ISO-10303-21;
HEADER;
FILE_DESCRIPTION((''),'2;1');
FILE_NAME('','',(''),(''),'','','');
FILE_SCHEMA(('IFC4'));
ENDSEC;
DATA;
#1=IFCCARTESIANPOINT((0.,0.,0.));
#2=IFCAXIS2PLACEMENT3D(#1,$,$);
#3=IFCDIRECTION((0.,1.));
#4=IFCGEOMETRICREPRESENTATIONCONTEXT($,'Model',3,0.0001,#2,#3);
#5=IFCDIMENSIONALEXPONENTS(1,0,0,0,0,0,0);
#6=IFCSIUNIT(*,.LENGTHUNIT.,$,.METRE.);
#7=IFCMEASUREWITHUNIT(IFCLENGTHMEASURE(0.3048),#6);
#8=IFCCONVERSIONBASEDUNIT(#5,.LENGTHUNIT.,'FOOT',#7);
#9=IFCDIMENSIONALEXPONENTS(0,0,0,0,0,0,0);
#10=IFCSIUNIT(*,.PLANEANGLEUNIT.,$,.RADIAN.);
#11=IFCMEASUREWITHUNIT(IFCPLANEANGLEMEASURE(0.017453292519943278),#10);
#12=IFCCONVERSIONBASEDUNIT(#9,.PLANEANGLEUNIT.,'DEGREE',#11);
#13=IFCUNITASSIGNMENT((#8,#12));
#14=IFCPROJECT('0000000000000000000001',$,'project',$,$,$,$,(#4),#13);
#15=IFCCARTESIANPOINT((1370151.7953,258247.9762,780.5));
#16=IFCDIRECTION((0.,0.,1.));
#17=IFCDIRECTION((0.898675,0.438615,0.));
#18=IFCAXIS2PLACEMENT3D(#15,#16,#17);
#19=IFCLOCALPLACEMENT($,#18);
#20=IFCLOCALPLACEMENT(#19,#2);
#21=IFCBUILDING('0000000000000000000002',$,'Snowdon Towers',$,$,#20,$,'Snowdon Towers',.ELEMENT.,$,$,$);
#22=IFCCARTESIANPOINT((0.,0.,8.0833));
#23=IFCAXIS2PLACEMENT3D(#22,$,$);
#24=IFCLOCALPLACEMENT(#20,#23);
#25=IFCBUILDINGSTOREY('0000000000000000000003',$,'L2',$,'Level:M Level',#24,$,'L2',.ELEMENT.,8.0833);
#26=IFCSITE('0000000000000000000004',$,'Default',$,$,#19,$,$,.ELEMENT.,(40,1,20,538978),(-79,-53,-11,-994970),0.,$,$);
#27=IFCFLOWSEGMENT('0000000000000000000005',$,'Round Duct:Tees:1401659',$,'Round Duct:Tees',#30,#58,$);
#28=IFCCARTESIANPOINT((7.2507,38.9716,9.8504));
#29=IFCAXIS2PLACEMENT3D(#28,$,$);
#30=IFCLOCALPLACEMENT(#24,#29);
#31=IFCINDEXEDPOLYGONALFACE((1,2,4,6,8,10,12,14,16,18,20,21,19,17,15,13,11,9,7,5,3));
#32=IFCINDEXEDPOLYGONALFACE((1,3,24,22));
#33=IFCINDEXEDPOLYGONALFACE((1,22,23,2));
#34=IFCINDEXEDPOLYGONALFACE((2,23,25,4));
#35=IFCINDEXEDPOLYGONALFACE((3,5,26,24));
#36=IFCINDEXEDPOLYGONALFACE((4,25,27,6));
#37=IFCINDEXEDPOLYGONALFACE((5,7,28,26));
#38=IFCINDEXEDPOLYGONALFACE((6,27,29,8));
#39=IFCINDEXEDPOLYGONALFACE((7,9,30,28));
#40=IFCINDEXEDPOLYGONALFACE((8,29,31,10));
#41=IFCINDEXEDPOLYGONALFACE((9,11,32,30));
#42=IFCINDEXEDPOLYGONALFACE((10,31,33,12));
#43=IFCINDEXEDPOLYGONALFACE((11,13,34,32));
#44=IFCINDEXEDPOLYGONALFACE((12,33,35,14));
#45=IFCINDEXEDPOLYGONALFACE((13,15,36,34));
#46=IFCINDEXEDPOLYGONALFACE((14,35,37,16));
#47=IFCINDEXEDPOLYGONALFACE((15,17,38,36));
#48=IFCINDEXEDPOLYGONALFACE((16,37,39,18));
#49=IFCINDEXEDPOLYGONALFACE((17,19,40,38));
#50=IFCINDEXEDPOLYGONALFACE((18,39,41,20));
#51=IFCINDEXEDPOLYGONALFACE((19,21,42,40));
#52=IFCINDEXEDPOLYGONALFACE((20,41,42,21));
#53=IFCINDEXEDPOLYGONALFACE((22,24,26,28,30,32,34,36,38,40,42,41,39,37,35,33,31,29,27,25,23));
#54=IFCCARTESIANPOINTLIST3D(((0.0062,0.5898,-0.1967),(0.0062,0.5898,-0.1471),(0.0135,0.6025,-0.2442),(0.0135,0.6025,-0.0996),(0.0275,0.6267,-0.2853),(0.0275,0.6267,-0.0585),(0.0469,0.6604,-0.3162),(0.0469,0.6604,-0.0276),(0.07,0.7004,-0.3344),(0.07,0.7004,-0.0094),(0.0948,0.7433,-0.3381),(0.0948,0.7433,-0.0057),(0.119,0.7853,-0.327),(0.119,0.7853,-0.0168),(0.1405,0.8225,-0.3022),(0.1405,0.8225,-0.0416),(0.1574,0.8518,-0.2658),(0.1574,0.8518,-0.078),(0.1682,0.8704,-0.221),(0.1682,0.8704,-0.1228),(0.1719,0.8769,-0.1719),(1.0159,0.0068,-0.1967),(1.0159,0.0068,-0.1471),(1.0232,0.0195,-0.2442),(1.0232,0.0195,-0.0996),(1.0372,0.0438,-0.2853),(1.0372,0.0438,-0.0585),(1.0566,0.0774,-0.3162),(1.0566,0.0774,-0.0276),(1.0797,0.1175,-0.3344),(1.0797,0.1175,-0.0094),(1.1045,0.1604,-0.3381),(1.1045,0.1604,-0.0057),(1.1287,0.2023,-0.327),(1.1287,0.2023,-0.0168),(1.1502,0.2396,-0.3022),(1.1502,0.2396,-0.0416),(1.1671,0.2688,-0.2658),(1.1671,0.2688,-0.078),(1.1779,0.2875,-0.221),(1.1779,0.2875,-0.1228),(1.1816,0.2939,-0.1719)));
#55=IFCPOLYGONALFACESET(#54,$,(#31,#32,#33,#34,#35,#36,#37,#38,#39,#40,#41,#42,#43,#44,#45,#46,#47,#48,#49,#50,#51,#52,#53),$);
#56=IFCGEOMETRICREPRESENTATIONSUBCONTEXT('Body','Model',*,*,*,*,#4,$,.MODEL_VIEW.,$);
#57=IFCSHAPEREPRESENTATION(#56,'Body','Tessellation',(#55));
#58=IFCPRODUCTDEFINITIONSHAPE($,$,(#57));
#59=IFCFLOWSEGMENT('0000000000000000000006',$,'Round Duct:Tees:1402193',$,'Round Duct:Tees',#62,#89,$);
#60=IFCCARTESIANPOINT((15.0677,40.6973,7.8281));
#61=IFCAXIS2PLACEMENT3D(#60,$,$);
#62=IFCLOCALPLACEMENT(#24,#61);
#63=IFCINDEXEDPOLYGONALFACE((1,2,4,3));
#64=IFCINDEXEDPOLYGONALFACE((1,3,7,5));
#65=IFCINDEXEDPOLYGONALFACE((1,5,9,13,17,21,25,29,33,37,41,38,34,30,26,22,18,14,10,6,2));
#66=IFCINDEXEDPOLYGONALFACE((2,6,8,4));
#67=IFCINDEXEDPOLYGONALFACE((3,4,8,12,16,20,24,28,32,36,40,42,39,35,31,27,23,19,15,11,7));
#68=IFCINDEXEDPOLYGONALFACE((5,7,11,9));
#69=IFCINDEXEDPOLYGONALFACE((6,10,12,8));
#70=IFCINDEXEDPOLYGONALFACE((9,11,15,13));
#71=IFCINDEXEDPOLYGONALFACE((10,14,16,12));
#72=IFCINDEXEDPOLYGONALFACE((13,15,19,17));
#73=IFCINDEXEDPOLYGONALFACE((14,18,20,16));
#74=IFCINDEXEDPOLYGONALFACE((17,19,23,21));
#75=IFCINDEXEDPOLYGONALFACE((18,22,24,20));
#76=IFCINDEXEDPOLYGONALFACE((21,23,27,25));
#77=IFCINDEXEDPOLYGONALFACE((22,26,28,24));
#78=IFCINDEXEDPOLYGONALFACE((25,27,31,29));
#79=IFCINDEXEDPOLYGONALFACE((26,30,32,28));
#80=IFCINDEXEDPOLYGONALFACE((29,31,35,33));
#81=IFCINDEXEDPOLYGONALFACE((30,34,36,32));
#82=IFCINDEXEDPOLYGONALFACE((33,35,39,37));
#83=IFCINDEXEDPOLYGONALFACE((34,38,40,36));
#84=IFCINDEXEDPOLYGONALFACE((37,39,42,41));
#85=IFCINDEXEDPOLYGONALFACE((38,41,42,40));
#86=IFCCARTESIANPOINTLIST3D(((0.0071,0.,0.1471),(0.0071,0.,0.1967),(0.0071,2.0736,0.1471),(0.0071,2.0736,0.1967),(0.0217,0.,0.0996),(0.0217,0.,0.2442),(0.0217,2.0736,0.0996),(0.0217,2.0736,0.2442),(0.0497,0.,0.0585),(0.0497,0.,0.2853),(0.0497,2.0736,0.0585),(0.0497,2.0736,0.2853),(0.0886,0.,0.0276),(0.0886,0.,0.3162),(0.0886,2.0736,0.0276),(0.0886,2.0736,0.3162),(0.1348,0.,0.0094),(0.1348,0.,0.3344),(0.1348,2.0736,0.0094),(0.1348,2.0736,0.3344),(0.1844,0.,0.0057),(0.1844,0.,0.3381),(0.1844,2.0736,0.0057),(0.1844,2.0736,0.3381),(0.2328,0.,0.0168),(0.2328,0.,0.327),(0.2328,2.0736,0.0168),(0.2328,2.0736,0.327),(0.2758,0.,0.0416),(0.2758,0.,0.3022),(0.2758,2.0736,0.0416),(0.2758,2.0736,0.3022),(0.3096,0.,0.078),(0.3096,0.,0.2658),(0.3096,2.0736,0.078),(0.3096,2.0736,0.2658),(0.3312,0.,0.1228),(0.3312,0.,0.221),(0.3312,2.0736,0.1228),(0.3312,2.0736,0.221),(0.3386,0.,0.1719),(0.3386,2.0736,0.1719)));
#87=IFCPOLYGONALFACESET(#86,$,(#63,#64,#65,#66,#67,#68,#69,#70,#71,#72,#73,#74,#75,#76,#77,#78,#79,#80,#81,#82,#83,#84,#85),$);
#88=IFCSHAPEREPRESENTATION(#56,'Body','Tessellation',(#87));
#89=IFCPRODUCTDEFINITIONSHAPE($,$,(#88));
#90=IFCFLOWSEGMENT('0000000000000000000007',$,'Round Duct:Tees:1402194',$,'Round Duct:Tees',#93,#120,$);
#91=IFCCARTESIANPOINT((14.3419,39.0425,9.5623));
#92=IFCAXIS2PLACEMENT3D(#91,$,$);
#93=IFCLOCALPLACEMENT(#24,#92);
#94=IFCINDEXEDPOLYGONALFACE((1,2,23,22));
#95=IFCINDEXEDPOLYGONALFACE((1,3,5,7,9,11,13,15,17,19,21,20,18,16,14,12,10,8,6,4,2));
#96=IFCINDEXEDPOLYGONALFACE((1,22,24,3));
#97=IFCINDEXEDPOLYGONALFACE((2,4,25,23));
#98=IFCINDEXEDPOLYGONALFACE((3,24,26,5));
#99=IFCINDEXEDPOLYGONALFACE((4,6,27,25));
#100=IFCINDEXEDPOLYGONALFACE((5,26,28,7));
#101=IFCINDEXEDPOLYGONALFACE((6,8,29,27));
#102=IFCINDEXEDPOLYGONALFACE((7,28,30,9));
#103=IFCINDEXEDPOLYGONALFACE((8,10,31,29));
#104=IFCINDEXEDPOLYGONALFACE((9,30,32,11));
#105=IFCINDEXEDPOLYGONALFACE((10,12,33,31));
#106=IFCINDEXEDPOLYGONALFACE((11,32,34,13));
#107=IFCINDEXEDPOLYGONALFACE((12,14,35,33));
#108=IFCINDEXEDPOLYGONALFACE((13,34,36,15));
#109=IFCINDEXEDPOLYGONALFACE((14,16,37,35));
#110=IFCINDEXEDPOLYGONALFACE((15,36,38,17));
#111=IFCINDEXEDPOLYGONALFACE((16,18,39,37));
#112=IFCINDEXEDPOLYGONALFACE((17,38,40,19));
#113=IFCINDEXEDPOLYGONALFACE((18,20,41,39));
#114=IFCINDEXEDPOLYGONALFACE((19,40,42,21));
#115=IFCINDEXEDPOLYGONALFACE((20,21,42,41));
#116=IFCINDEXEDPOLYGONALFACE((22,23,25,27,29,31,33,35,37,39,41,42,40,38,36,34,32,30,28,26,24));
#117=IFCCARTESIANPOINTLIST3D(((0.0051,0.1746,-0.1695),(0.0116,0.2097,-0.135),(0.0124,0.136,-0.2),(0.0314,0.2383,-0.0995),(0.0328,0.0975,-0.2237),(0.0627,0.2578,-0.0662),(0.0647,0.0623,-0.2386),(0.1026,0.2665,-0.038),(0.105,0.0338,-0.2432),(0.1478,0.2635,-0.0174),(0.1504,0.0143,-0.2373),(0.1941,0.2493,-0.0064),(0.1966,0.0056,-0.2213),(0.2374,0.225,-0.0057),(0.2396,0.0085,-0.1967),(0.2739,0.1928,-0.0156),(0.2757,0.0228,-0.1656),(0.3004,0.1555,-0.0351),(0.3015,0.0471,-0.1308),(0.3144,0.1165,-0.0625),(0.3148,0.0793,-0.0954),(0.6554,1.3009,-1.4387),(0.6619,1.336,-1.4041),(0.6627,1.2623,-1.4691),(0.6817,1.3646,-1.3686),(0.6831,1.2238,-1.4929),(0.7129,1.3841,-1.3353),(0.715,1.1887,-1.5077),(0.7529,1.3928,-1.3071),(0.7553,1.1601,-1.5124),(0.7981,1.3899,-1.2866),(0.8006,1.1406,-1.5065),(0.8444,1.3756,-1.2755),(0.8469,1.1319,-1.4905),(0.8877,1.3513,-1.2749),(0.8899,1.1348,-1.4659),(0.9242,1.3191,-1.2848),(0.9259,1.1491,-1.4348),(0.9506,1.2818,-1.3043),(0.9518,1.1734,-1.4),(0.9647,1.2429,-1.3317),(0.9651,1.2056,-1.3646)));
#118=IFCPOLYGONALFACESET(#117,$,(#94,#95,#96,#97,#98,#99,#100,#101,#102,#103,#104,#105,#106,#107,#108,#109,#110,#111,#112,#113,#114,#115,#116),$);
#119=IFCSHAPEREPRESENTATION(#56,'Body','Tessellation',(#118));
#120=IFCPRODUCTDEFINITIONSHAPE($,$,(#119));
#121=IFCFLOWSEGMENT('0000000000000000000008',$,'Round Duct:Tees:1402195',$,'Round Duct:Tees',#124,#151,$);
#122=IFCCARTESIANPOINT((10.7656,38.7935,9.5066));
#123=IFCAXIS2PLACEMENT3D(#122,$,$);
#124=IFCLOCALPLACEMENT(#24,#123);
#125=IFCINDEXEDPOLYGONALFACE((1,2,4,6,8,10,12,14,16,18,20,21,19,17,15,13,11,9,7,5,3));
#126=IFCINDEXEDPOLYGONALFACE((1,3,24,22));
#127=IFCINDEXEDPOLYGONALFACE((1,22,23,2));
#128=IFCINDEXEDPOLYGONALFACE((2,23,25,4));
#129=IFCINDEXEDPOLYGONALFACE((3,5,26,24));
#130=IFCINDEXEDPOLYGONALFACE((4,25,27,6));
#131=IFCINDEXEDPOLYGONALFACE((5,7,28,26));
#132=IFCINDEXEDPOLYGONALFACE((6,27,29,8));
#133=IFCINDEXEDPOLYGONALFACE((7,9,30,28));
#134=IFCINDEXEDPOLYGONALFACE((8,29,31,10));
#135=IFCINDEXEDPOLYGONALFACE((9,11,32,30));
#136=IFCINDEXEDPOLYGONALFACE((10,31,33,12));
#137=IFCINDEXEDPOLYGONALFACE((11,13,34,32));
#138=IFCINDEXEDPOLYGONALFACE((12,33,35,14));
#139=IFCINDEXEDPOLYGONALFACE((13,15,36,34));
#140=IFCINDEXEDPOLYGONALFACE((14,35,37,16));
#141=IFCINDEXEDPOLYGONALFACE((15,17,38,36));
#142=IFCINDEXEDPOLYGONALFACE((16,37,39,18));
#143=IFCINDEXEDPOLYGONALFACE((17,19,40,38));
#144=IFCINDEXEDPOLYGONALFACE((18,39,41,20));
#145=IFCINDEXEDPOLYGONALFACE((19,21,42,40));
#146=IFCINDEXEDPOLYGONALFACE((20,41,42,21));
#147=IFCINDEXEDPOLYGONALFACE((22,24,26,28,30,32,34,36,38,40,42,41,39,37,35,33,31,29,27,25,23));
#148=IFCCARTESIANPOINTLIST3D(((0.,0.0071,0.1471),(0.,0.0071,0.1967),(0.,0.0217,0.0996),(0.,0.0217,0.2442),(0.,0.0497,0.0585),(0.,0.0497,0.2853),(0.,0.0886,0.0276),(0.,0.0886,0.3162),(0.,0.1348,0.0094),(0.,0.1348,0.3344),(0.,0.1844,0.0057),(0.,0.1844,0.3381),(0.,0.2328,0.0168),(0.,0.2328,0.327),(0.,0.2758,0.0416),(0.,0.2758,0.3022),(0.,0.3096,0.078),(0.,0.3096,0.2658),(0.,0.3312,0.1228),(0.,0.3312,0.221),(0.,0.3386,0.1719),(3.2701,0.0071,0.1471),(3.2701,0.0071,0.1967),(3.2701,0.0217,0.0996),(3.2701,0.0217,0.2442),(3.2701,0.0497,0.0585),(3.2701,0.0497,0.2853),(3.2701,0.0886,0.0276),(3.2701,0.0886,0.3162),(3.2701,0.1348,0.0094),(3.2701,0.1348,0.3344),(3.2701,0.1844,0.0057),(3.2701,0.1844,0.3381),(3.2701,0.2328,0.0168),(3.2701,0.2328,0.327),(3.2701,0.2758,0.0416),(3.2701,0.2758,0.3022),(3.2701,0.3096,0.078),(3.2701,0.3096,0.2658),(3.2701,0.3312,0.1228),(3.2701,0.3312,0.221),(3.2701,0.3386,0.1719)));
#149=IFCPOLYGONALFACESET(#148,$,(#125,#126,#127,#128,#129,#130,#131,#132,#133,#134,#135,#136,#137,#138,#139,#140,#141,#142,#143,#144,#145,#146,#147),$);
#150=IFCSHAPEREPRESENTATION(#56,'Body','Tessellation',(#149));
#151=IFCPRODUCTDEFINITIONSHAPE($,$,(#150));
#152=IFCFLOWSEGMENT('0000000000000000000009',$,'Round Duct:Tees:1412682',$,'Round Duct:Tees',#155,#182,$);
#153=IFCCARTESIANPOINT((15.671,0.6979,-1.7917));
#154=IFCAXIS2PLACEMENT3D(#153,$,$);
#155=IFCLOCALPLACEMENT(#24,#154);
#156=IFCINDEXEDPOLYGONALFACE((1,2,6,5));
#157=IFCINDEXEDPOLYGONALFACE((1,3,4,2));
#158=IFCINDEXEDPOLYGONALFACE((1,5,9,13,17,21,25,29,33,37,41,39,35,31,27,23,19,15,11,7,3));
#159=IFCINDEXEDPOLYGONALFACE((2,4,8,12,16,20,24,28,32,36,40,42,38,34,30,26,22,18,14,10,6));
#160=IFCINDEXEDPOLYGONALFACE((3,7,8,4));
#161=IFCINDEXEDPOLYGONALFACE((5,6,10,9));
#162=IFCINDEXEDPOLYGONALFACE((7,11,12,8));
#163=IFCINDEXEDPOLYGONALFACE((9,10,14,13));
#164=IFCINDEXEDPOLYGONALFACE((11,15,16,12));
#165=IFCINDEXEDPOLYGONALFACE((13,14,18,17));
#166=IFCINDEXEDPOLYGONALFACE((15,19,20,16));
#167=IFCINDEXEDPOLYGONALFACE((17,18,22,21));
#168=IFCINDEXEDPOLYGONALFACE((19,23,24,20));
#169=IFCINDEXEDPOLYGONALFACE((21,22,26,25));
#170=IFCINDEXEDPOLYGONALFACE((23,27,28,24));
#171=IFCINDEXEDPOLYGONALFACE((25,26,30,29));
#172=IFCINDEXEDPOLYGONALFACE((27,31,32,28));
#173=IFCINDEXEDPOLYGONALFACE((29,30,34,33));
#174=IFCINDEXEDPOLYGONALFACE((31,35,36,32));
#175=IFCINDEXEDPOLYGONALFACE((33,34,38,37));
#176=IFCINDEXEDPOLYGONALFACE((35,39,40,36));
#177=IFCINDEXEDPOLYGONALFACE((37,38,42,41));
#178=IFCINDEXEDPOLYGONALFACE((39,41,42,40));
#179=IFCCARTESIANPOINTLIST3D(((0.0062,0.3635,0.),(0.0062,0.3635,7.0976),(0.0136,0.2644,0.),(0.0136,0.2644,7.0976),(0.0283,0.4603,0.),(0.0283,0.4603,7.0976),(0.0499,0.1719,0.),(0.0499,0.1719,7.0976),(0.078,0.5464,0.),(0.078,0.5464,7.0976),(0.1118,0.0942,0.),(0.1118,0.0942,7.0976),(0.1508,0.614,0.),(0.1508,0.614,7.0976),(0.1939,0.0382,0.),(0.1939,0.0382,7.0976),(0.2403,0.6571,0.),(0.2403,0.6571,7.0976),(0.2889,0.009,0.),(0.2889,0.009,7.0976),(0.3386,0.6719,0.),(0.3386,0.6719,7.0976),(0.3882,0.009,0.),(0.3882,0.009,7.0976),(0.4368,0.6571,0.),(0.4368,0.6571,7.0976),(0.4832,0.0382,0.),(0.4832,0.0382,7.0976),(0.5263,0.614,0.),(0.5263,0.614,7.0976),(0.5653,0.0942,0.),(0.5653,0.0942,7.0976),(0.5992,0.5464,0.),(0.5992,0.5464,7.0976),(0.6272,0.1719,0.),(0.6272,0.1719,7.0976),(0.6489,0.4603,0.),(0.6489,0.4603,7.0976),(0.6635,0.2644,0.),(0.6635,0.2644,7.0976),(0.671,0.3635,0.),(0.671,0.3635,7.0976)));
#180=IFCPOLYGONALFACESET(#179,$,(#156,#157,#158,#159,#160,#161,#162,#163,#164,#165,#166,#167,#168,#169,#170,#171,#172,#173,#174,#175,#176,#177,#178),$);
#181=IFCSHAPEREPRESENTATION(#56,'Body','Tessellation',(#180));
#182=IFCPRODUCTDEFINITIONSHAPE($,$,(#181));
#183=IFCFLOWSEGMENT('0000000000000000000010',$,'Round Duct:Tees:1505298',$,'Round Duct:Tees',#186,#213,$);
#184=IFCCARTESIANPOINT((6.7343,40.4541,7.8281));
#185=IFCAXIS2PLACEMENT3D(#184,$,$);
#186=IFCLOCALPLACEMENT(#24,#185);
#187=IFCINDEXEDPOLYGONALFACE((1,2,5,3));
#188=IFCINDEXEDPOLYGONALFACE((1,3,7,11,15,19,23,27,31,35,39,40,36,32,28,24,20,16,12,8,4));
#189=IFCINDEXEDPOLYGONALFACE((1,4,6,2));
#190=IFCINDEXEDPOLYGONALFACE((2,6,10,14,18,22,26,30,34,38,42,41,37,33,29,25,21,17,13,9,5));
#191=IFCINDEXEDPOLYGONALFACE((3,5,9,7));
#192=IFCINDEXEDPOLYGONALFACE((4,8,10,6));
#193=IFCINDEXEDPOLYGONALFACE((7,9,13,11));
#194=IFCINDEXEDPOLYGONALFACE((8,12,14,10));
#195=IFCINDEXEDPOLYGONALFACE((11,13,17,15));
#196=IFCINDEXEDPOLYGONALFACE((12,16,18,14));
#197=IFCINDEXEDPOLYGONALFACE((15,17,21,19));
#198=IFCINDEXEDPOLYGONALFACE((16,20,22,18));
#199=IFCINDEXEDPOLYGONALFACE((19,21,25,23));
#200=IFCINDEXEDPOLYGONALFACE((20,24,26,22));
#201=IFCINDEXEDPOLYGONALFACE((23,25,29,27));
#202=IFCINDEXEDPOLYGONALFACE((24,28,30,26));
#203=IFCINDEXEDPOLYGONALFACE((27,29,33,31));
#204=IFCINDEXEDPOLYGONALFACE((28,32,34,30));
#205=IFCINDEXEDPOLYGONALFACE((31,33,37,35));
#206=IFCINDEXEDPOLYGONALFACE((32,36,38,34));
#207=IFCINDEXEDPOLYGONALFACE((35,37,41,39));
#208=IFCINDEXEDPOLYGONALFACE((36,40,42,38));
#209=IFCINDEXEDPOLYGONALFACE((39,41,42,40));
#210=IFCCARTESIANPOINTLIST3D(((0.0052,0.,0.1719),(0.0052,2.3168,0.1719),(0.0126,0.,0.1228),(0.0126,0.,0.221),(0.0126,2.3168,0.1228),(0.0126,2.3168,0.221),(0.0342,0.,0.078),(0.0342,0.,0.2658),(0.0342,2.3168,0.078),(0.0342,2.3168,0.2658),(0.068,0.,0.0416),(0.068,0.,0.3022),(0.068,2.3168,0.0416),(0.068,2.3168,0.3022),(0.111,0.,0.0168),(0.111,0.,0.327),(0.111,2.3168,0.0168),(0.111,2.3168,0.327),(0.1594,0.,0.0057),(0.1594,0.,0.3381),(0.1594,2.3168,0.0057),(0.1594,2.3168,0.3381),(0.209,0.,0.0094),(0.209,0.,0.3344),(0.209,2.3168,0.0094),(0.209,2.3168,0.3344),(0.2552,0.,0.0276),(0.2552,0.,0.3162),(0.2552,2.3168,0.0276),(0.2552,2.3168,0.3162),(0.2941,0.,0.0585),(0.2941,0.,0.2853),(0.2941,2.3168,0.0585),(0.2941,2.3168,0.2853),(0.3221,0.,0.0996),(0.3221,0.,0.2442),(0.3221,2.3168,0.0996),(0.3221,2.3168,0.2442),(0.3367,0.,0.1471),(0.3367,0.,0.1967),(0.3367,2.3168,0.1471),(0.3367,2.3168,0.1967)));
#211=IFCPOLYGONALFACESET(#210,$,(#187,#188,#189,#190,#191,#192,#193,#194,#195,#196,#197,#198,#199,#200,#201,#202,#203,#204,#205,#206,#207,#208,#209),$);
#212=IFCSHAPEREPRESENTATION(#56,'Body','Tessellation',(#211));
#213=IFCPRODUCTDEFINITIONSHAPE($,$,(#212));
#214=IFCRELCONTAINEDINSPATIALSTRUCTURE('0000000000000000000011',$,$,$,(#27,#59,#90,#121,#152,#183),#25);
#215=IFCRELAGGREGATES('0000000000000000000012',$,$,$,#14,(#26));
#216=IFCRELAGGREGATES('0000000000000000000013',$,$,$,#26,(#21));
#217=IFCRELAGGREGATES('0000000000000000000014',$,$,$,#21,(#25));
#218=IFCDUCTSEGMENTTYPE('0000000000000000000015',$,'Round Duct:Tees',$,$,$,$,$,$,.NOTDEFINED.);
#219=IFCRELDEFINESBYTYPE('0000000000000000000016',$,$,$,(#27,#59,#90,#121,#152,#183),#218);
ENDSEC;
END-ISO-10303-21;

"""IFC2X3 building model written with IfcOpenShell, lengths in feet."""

from ifc_helpers import new_model, entity, si_unit, converted_unit, direction, frame, frame_2d, origin, origin_2d_with_axis, place, context, subcontext, project, spatial, circle, extrude, type_object, element, save


model = new_model("IFC2X3")

# Units and contexts
model_context = context("Model", 3, precision=0.0001, world=origin(), true_north=direction((0.0, 1.0)))
body_context = subcontext(model_context, "Body", "Model", "MODEL_VIEW")
ifc_project = project(units=[converted_unit("LENGTHUNIT", "FOOT", entity("IfcLengthMeasure", 0.3048), si_unit("LENGTHUNIT", "METRE"), dimensions=[1, 0, 0, 0, 0, 0, 0]), converted_unit("PLANEANGLEUNIT", "DEGREE", entity("IfcPlaneAngleMeasure", 0.017453292519943278), si_unit("PLANEANGLEUNIT", "RADIAN"), dimensions=[0, 0, 0, 0, 0, 0, 0])], contexts=[model_context])

# Site, building, storey
site_placement = place(None, frame((1370151.7953, 258247.9762, 780.5), z_axis=(0.0, 0.0, 1.0), x_axis=(0.898675, 0.438615, 0.0)))
site = spatial("IfcSite", under=ifc_project, at=site_placement, Name="Default", CompositionType="ELEMENT", RefLatitude=(40, 1, 20, 538978), RefLongitude=(-79, -53, -11, -994970), RefElevation=0.0)
building_placement = place(site_placement, origin())
building = spatial("IfcBuilding", under=site, at=building_placement, Name="Snowdon Towers", LongName="Snowdon Towers", CompositionType="ELEMENT")
storey_placement = place(building_placement, frame((0.0, 0.0, 8.0833)))
storey = spatial("IfcBuildingStorey", under=building, at=storey_placement, Name="L2", ObjectType="Level:M Level", LongName="L2", CompositionType="ELEMENT", Elevation=8.0833)

# Flow segments
duct_segment_type = type_object("IfcDuctSegmentType", Name="Round Duct:Tees", PredefinedType="NOTDEFINED")
flow_segment_1_placement = place(storey_placement, frame((7.2507, 38.9716, 9.8504)))
element("IfcFlowSegment", 1, at=flow_segment_1_placement, inside=storey, type_object=duct_segment_type, Name="Round Duct:Tees:1401659", ObjectType="Round Duct:Tees", context=body_context, shape_type="SweptSolid", body=[
    extrude(circle(Radius=0.1667, at=origin_2d_with_axis()), frame((0.0886, 0.7325, -0.1719), z_axis=(0.866025, -0.5, 0.0), x_axis=(0.5, 0.866025, 0.0)), (0.0, 0.0, 1.0), 1.1659),
])
flow_segment_2_placement = place(storey_placement, frame((15.0677, 40.6973, 7.8281)))
element("IfcFlowSegment", 2, at=flow_segment_2_placement, inside=storey, type_object=duct_segment_type, Name="Round Duct:Tees:1402193", ObjectType="Round Duct:Tees", context=body_context, shape_type="SweptSolid", body=[
    extrude(circle(Radius=0.1667, at=origin_2d_with_axis()), frame((0.1719, 0.0, 0.1719), z_axis=(0.0, 1.0, 0.0), x_axis=(1.0, 0.0, 0.0)), (0.0, 0.0, 1.0), 2.0736),
])
flow_segment_3_placement = place(storey_placement, frame((14.3419, 39.0425, 9.5623)))
element("IfcFlowSegment", 3, at=flow_segment_3_placement, inside=storey, type_object=duct_segment_type, Name="Round Duct:Tees:1402194", ObjectType="Round Duct:Tees", context=body_context, shape_type="SweptSolid", body=[
    extrude(circle(Radius=0.1667, at=frame_2d((0.0, 0.0), x_axis=(1.0, 0.0))), frame((0.1607, 0.136, -0.124), z_axis=(0.357849, 0.619812, -0.698411), x_axis=(-0.889978, 0.0, -0.456003)), (0.0, 0.0, 1.0), 1.8172),
])
flow_segment_4_placement = place(storey_placement, frame((10.7656, 38.7935, 9.5066)))
element("IfcFlowSegment", 4, at=flow_segment_4_placement, inside=storey, type_object=duct_segment_type, Name="Round Duct:Tees:1402195", ObjectType="Round Duct:Tees", context=body_context, shape_type="SweptSolid", body=[
    extrude(circle(Radius=0.1667, at=frame_2d((0.0, 0.0), x_axis=(1.0, 0.0))), frame((0.0, 0.1719, 0.1719), z_axis=(1.0, 0.0, 0.0), x_axis=(0.0, 1.0, 0.0)), (0.0, 0.0, 1.0), 3.2701),
])
flow_segment_5_placement = place(storey_placement, frame((15.671, 0.6979, -1.7917)))
element("IfcFlowSegment", 5, at=flow_segment_5_placement, inside=storey, type_object=duct_segment_type, Name="Round Duct:Tees:1412682", ObjectType="Round Duct:Tees", context=body_context, shape_type="SweptSolid", body=[
    extrude(circle(Radius=0.3333, at=frame_2d((0.0, 0.0), x_axis=(1.0, 0.0))), frame((0.3386, 0.3386, 0.0), z_axis=(0.0, 0.0, 1.0), x_axis=(0.0, 1.0, 0.0)), (0.0, 0.0, 1.0), 7.0976),
])
flow_segment_6_placement = place(storey_placement, frame((6.7343, 40.4541, 7.8281)))
element("IfcFlowSegment", 6, at=flow_segment_6_placement, inside=storey, type_object=duct_segment_type, Name="Round Duct:Tees:1505298", ObjectType="Round Duct:Tees", context=body_context, shape_type="SweptSolid", body=[
    extrude(circle(Radius=0.1667, at=frame_2d((0.0, 0.0), x_axis=(1.0, 0.0))), frame((0.1719, 0.0, 0.1719), z_axis=(0.0, 1.0, 0.0), x_axis=(-1.0, 0.0, 0.0)), (0.0, 0.0, 1.0), 2.3168),
])

save(model, "model.ifc")
